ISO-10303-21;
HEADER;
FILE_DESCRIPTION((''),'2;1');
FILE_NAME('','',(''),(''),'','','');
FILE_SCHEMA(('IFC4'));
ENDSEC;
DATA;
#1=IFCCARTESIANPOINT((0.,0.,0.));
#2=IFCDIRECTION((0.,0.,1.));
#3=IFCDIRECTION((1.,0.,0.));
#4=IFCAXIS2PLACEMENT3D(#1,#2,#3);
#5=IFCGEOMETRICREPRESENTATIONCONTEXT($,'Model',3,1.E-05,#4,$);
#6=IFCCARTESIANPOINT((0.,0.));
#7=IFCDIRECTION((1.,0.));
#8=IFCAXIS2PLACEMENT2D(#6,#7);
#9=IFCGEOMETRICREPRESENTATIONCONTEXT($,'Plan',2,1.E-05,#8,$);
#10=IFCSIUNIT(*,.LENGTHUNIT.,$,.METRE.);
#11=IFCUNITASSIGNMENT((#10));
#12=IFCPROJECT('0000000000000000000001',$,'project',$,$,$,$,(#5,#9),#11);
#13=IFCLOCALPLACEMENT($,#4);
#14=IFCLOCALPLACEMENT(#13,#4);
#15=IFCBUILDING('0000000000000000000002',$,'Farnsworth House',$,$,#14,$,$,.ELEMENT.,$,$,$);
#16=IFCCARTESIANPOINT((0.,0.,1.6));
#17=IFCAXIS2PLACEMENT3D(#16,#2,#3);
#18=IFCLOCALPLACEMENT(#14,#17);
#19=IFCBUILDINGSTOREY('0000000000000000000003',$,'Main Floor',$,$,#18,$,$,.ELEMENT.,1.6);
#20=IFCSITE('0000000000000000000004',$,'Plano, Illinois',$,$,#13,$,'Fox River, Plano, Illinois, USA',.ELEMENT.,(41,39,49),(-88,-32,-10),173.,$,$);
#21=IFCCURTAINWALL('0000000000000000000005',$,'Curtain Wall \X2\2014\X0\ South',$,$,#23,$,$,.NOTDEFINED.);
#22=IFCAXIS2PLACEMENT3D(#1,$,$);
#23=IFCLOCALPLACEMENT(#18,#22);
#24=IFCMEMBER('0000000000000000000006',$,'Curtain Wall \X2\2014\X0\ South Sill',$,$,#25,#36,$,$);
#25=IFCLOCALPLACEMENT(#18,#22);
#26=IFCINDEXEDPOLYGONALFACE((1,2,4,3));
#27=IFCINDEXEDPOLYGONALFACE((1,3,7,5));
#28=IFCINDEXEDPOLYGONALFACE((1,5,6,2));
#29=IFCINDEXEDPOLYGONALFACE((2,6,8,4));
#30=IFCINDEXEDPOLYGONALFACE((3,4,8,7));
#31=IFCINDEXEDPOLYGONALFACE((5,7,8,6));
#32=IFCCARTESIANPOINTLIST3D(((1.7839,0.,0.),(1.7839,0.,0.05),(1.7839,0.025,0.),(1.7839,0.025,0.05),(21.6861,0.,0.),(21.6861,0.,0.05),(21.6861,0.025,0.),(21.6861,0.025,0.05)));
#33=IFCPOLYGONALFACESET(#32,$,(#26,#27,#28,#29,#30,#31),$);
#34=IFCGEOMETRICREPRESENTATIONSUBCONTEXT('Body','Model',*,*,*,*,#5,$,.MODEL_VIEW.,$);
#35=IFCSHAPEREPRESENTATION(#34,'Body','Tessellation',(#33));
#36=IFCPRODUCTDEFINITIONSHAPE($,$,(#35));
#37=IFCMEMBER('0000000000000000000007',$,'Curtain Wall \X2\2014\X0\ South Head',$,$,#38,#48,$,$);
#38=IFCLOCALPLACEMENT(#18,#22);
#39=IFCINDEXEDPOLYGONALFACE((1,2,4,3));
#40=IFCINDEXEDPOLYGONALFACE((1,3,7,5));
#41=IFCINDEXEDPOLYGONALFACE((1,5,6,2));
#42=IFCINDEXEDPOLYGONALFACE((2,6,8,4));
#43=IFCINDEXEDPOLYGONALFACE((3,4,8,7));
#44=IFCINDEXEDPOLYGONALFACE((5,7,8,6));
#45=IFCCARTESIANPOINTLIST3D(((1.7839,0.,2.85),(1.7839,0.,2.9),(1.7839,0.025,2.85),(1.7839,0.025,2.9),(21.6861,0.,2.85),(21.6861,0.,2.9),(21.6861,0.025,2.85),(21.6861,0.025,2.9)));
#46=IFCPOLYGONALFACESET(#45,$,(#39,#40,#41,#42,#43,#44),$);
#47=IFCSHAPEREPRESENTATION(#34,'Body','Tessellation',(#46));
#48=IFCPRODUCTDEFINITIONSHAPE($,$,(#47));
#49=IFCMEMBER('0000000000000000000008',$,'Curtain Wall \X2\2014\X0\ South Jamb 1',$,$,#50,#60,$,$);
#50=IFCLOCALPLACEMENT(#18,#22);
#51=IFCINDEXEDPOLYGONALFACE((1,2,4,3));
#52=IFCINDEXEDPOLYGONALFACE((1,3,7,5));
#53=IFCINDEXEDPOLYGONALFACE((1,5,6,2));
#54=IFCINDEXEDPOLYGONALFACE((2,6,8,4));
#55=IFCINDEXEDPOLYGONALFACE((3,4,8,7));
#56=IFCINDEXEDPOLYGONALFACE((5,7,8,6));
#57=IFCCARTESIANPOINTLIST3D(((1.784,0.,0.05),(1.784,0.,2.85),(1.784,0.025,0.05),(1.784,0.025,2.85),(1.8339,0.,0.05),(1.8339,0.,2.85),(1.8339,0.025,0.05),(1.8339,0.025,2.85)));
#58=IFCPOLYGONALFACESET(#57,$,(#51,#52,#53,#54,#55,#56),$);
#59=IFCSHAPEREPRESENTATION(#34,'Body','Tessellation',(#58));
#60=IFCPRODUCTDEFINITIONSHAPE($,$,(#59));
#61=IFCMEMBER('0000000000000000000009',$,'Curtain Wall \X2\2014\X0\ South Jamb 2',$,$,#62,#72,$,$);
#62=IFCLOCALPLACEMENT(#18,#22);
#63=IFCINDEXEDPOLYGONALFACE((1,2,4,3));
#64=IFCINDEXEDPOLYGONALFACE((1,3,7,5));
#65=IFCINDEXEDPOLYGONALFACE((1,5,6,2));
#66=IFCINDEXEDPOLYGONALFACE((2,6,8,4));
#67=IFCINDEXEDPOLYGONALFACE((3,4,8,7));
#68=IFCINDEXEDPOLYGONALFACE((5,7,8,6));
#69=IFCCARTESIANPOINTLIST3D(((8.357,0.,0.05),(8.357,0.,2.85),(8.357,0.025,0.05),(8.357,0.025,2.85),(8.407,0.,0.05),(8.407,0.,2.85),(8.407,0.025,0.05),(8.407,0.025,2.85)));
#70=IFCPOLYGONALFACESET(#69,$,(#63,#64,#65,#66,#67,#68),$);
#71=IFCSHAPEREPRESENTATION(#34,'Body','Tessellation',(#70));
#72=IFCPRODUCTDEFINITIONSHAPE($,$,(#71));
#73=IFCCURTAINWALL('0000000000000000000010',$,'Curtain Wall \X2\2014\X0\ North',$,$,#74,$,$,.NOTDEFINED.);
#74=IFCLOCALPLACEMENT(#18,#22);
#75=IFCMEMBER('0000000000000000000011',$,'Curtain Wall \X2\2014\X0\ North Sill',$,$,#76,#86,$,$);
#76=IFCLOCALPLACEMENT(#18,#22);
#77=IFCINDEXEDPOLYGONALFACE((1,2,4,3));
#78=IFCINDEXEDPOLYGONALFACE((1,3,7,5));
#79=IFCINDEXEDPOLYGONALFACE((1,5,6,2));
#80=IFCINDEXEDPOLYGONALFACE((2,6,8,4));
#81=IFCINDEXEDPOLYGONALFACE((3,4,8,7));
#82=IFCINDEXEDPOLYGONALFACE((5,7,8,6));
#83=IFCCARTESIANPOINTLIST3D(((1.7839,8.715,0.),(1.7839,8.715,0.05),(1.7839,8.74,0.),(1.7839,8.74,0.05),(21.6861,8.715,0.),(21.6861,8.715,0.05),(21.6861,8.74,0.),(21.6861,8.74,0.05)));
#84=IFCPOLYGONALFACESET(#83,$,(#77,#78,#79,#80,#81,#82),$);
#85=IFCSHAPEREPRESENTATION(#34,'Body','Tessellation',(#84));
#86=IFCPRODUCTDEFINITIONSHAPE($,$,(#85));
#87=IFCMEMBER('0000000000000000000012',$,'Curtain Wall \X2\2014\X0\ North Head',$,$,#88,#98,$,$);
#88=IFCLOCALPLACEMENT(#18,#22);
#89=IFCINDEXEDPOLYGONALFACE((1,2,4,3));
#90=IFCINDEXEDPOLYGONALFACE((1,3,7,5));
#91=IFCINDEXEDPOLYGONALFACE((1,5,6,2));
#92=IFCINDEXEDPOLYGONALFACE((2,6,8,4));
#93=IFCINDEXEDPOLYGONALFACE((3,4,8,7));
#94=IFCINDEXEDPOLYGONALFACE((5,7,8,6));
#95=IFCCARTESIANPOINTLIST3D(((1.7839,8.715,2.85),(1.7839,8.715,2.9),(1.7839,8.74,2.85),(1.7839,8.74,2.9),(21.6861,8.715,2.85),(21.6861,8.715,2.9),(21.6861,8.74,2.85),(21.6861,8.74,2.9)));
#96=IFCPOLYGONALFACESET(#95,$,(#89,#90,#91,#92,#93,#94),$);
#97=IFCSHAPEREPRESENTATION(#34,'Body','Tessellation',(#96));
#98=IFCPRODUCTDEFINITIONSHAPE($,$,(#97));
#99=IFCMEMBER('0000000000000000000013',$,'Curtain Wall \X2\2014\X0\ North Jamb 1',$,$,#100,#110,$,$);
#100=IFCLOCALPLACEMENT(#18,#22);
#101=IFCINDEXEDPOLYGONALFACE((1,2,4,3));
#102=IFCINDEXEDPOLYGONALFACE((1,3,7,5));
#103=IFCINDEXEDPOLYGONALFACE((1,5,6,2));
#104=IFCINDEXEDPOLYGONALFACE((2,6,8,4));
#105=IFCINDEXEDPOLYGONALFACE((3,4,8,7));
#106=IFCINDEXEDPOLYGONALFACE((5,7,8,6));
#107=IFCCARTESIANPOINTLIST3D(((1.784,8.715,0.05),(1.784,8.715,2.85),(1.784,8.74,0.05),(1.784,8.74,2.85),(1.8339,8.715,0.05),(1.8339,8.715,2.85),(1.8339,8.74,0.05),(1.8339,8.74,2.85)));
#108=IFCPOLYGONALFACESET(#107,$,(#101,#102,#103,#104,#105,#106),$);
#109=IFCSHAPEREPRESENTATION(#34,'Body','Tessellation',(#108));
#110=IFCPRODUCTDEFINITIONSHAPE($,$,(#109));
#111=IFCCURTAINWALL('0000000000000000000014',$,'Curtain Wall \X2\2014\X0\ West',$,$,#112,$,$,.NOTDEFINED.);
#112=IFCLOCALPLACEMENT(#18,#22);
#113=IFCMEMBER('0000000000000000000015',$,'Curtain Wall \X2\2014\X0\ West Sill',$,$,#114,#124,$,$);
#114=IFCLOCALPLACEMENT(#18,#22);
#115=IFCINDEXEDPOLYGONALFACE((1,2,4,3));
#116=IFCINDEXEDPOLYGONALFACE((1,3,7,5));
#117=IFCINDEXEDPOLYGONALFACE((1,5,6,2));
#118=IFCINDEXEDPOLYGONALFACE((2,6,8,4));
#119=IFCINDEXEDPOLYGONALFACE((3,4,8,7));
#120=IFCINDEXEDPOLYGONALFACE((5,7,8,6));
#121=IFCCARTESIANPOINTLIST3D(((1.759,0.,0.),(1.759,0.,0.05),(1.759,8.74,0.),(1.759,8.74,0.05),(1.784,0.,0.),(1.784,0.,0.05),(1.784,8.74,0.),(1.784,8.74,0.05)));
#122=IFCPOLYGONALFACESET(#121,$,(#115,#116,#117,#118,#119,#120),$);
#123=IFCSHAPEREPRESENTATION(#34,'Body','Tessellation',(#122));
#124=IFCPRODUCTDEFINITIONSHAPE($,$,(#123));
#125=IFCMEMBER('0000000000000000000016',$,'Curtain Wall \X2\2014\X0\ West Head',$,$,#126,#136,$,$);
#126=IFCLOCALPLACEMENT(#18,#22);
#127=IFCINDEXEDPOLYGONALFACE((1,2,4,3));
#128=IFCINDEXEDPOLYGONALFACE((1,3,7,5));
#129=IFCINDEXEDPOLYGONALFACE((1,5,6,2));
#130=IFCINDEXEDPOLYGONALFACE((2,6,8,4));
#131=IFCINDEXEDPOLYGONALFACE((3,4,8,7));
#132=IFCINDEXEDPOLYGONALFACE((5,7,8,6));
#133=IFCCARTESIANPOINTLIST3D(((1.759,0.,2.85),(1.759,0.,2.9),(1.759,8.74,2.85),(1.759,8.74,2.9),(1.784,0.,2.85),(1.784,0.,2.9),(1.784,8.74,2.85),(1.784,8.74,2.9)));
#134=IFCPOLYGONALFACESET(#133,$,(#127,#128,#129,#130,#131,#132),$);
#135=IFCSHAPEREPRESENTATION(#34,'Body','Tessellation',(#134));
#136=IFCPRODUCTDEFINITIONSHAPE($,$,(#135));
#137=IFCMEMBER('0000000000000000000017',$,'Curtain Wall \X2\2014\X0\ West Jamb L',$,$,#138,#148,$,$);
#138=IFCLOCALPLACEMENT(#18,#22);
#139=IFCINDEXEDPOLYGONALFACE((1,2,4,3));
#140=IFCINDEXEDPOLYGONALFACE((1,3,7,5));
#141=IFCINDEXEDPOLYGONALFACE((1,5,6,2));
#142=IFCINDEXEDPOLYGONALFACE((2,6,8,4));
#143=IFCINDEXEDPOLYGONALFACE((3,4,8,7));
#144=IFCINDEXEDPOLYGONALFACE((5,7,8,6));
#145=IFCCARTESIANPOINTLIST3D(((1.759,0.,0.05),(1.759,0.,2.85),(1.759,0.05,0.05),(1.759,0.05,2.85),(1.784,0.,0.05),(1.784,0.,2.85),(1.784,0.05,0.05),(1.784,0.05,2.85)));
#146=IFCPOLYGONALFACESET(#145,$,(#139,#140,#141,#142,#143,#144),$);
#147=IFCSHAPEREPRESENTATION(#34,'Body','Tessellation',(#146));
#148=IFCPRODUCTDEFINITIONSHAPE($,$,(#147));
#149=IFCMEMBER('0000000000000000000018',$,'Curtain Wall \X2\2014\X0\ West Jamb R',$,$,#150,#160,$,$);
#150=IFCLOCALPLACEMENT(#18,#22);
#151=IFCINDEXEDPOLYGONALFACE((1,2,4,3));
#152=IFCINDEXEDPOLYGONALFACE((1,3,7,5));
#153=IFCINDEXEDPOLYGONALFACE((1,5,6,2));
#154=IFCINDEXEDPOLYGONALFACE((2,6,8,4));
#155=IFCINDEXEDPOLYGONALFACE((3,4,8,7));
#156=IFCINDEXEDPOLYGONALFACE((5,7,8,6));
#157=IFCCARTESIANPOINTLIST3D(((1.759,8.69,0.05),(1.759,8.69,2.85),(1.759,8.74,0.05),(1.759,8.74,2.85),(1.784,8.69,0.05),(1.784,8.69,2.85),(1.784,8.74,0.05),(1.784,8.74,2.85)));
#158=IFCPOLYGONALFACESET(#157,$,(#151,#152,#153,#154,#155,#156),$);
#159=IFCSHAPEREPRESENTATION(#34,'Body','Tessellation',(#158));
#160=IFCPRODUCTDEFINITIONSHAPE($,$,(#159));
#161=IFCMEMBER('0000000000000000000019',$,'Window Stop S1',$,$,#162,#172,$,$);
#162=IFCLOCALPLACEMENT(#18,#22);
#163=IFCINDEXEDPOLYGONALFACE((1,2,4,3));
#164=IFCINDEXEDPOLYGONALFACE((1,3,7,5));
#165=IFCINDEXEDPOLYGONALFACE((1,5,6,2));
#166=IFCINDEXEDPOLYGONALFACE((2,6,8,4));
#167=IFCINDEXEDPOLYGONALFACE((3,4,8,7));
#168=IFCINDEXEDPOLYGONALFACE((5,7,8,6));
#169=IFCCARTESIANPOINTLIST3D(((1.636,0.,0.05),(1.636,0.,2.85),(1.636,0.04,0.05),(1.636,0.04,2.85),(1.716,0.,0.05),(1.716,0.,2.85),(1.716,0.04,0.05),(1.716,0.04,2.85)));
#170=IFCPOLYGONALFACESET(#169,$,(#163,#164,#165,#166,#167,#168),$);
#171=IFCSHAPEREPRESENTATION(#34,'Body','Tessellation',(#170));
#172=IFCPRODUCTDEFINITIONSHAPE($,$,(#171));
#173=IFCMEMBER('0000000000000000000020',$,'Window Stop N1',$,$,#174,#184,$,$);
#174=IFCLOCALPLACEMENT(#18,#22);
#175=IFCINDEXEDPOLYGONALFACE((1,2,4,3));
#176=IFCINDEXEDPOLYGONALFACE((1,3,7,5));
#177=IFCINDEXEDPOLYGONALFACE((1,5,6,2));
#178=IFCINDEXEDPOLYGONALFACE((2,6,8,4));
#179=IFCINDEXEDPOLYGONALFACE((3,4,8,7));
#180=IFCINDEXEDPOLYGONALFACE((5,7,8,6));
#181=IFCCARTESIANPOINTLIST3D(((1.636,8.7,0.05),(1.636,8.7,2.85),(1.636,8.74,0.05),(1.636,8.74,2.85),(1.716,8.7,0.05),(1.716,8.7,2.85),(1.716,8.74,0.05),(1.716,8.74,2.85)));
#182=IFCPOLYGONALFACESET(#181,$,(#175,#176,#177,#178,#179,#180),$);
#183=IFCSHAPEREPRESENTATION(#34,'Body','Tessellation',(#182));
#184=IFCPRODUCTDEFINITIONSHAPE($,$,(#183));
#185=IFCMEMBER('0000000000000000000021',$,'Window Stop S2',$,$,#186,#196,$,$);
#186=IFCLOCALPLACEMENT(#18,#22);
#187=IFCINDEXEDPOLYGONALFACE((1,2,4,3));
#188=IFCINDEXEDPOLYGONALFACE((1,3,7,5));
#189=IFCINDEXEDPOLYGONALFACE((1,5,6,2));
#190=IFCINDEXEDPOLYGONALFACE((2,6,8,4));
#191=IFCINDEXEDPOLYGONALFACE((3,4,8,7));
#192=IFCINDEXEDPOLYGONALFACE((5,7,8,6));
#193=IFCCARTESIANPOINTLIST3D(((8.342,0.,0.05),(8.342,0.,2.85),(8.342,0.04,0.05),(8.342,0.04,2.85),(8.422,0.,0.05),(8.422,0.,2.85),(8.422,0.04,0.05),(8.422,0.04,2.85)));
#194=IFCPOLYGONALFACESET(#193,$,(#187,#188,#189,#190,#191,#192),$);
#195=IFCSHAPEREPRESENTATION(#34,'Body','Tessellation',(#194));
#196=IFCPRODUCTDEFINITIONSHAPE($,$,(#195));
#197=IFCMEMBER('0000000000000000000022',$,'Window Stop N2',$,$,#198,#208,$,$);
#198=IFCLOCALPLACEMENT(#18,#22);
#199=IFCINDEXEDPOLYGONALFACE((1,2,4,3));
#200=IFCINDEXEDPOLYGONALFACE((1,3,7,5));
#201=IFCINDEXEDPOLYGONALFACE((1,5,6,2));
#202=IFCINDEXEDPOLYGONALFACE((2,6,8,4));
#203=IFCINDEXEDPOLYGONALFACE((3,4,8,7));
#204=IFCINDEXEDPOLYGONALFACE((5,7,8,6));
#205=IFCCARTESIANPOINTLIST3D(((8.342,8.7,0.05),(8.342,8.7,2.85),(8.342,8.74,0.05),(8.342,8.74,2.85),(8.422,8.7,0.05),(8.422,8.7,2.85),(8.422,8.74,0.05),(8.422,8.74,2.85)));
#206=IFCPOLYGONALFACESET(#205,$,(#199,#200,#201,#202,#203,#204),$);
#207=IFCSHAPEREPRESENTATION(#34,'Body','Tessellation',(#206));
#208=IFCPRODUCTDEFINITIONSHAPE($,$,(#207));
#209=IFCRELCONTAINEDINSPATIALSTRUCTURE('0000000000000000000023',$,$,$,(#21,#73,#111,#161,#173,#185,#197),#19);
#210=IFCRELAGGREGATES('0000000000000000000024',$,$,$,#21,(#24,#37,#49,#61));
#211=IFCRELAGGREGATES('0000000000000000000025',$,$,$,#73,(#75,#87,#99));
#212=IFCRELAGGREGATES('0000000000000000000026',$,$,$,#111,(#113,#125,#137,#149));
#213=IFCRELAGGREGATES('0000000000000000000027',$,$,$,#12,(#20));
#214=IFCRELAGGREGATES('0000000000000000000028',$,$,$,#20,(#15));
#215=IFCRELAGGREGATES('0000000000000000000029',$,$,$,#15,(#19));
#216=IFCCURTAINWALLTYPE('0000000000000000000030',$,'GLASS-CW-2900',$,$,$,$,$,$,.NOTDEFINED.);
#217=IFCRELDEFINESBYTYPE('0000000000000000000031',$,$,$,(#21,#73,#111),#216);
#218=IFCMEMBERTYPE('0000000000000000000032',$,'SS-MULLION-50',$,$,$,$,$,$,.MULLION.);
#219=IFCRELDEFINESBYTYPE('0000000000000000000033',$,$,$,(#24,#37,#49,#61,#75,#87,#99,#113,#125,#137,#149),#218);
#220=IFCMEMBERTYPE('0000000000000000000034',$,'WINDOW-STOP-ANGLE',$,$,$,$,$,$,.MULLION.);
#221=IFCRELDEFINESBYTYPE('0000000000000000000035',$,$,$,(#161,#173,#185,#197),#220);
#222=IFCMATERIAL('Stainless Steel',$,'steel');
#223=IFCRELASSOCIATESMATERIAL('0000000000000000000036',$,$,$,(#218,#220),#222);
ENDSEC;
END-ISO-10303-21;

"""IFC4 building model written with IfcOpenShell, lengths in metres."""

from ifc_helpers import new_model, si_unit, frame, origin_with_axes, origin_2d_with_axis, place, context, subcontext, project, spatial, rectangle, extrude, material, type_object, element, aggregate, save


model = new_model("IFC4")

# Units and contexts
model_context = context("Model", 3, precision=1e-05, world=origin_with_axes())
plan_context = context("Plan", 2, precision=1e-05, world=origin_2d_with_axis())
body_context = subcontext(model_context, "Body", "Model", "MODEL_VIEW")
ifc_project = project(units=[si_unit("LENGTHUNIT", "METRE")], contexts=[model_context, plan_context])

# Site, building, storey
site_placement = place(None, origin_with_axes())
site = spatial("IfcSite", under=ifc_project, at=site_placement, Name="Plano, Illinois", LongName="Fox River, Plano, Illinois, USA", CompositionType="ELEMENT", RefLatitude=(41, 39, 49), RefLongitude=(-88, -32, -10), RefElevation=173.0)
building_placement = place(site_placement, origin_with_axes())
building = spatial("IfcBuilding", under=site, at=building_placement, Name="Farnsworth House", CompositionType="ELEMENT")
storey_placement = place(building_placement, frame((0.0, 0.0, 1.6), z_axis=(0.0, 0.0, 1.0), x_axis=(1.0, 0.0, 0.0)))
storey = spatial("IfcBuildingStorey", under=building, at=storey_placement, Name="Main Floor", CompositionType="ELEMENT", Elevation=1.6)

# Curtain walls, members
curtain_wall_type = type_object("IfcCurtainWallType", Name="GLASS-CW-2900", PredefinedType="NOTDEFINED")
curtain_wall_1_placement = place(storey_placement, frame((1.7839, 0.0, 0.0), z_axis=(0.0, 0.0, 1.0), x_axis=(1.0, 0.0, 0.0)))
curtain_wall_1 = element("IfcCurtainWall", 1, at=curtain_wall_1_placement, inside=storey, type_object=curtain_wall_type, Name="Curtain Wall — South", PredefinedType="NOTDEFINED")
ifc_material_1 = material(Name="Stainless Steel", Category="steel")
member_type_1 = type_object("IfcMemberType", Name="SS-MULLION-50", PredefinedType="MULLION", material=ifc_material_1)
member_1_placement = place(curtain_wall_1_placement, origin_with_axes())
member_1 = element("IfcMember", 2, at=member_1_placement, type_object=member_type_1, Name="Curtain Wall — South Sill", context=body_context, shape_type="SweptSolid", body=[
    extrude(rectangle(XDim=19.9021, YDim=0.025, at=origin_2d_with_axis()), frame((9.9511, 0.0125, 0.0), z_axis=(0.0, 0.0, 1.0), x_axis=(1.0, 0.0, 0.0)), (0.0, 0.0, 1.0), 0.05),
])
member_2_placement = place(curtain_wall_1_placement, frame((0.0, 0.0, 2.85), z_axis=(0.0, 0.0, 1.0), x_axis=(1.0, 0.0, 0.0)))
member_2 = element("IfcMember", 3, at=member_2_placement, type_object=member_type_1, Name="Curtain Wall — South Head", context=body_context, shape_type="SweptSolid", body=[
    extrude(rectangle(XDim=19.9021, YDim=0.025, at=origin_2d_with_axis()), frame((9.9511, 0.0125, 0.0), z_axis=(0.0, 0.0, 1.0), x_axis=(1.0, 0.0, 0.0)), (0.0, 0.0, 1.0), 0.05),
])
member_3_placement = place(curtain_wall_1_placement, frame((0.0, 0.0, 0.05), z_axis=(0.0, 0.0, 1.0), x_axis=(1.0, 0.0, 0.0)))
member_3 = element("IfcMember", 4, at=member_3_placement, type_object=member_type_1, Name="Curtain Wall — South Jamb 1", context=body_context, shape_type="SweptSolid", body=[
    extrude(rectangle(XDim=0.05, YDim=0.025, at=origin_2d_with_axis()), frame((0.025, 0.0125, 0.0), z_axis=(0.0, 0.0, 1.0), x_axis=(1.0, 0.0, 0.0)), (0.0, 0.0, 1.0), 2.8),
])
member_4_placement = place(curtain_wall_1_placement, frame((6.573, 0.0, 0.05), z_axis=(0.0, 0.0, 1.0), x_axis=(1.0, 0.0, 0.0)))
member_4 = element("IfcMember", 5, at=member_4_placement, type_object=member_type_1, Name="Curtain Wall — South Jamb 2", context=body_context, shape_type="SweptSolid", body=[
    extrude(rectangle(XDim=0.05, YDim=0.025, at=origin_2d_with_axis()), frame((0.025, 0.0125, 0.0), z_axis=(0.0, 0.0, 1.0), x_axis=(1.0, 0.0, 0.0)), (0.0, 0.0, 1.0), 2.8),
])
curtain_wall_2_placement = place(storey_placement, frame((1.7839, 8.715, 0.0), z_axis=(0.0, 0.0, 1.0), x_axis=(1.0, 0.0, 0.0)))
curtain_wall_2 = element("IfcCurtainWall", 6, at=curtain_wall_2_placement, inside=storey, type_object=curtain_wall_type, Name="Curtain Wall — North", PredefinedType="NOTDEFINED")
member_5_placement = place(curtain_wall_2_placement, origin_with_axes())
member_5 = element("IfcMember", 7, at=member_5_placement, type_object=member_type_1, Name="Curtain Wall — North Sill", context=body_context, shape_type="SweptSolid", body=[
    extrude(rectangle(XDim=19.9021, YDim=0.025, at=origin_2d_with_axis()), frame((9.9511, 0.0125, 0.0), z_axis=(0.0, 0.0, 1.0), x_axis=(1.0, 0.0, 0.0)), (0.0, 0.0, 1.0), 0.05),
])
member_6_placement = place(curtain_wall_2_placement, frame((0.0, 0.0, 2.85), z_axis=(0.0, 0.0, 1.0), x_axis=(1.0, 0.0, 0.0)))
member_6 = element("IfcMember", 8, at=member_6_placement, type_object=member_type_1, Name="Curtain Wall — North Head", context=body_context, shape_type="SweptSolid", body=[
    extrude(rectangle(XDim=19.9021, YDim=0.025, at=origin_2d_with_axis()), frame((9.9511, 0.0125, 0.0), z_axis=(0.0, 0.0, 1.0), x_axis=(1.0, 0.0, 0.0)), (0.0, 0.0, 1.0), 0.05),
])
member_7_placement = place(curtain_wall_2_placement, frame((0.0, 0.0, 0.05), z_axis=(0.0, 0.0, 1.0), x_axis=(1.0, 0.0, 0.0)))
member_7 = element("IfcMember", 9, at=member_7_placement, type_object=member_type_1, Name="Curtain Wall — North Jamb 1", context=body_context, shape_type="SweptSolid", body=[
    extrude(rectangle(XDim=0.05, YDim=0.025, at=origin_2d_with_axis()), frame((0.025, 0.0125, 0.0), z_axis=(0.0, 0.0, 1.0), x_axis=(1.0, 0.0, 0.0)), (0.0, 0.0, 1.0), 2.8),
])
curtain_wall_3_placement = place(storey_placement, frame((1.7839, 0.0, 0.0), z_axis=(0.0, 0.0, 1.0), x_axis=(0.0, 1.0, 0.0)))
curtain_wall_3 = element("IfcCurtainWall", 10, at=curtain_wall_3_placement, inside=storey, type_object=curtain_wall_type, Name="Curtain Wall — West", PredefinedType="NOTDEFINED")
member_8_placement = place(curtain_wall_3_placement, origin_with_axes())
member_8 = element("IfcMember", 11, at=member_8_placement, type_object=member_type_1, Name="Curtain Wall — West Sill", context=body_context, shape_type="SweptSolid", body=[
    extrude(rectangle(XDim=8.74, YDim=0.025, at=origin_2d_with_axis()), frame((4.37, 0.0125, 0.0), z_axis=(0.0, 0.0, 1.0), x_axis=(1.0, 0.0, 0.0)), (0.0, 0.0, 1.0), 0.05),
])
member_9_placement = place(curtain_wall_3_placement, frame((0.0, 0.0, 2.85), z_axis=(0.0, 0.0, 1.0), x_axis=(1.0, 0.0, 0.0)))
member_9 = element("IfcMember", 12, at=member_9_placement, type_object=member_type_1, Name="Curtain Wall — West Head", context=body_context, shape_type="SweptSolid", body=[
    extrude(rectangle(XDim=8.74, YDim=0.025, at=origin_2d_with_axis()), frame((4.37, 0.0125, 0.0), z_axis=(0.0, 0.0, 1.0), x_axis=(1.0, 0.0, 0.0)), (0.0, 0.0, 1.0), 0.05),
])
member_10_placement = place(curtain_wall_3_placement, frame((0.0, 0.0, 0.05), z_axis=(0.0, 0.0, 1.0), x_axis=(1.0, 0.0, 0.0)))
member_10 = element("IfcMember", 13, at=member_10_placement, type_object=member_type_1, Name="Curtain Wall — West Jamb L", context=body_context, shape_type="SweptSolid", body=[
    extrude(rectangle(XDim=0.05, YDim=0.025, at=origin_2d_with_axis()), frame((0.025, 0.0125, 0.0), z_axis=(0.0, 0.0, 1.0), x_axis=(1.0, 0.0, 0.0)), (0.0, 0.0, 1.0), 2.8),
])
member_11_placement = place(curtain_wall_3_placement, frame((8.69, 0.0, 0.05), z_axis=(0.0, 0.0, 1.0), x_axis=(1.0, 0.0, 0.0)))
member_11 = element("IfcMember", 14, at=member_11_placement, type_object=member_type_1, Name="Curtain Wall — West Jamb R", context=body_context, shape_type="SweptSolid", body=[
    extrude(rectangle(XDim=0.05, YDim=0.025, at=origin_2d_with_axis()), frame((0.025, 0.0125, 0.0), z_axis=(0.0, 0.0, 1.0), x_axis=(1.0, 0.0, 0.0)), (0.0, 0.0, 1.0), 2.8),
])

# Members
member_type_2 = type_object("IfcMemberType", Name="WINDOW-STOP-ANGLE", PredefinedType="MULLION", material=ifc_material_1)
for number, where, z_axis, x_axis, name in (
    (15, (1.636, 0.0, 0.05), (0.0, 0.0, 1.0), (1.0, 0.0, 0.0), "Window Stop S1"),
    (16, (1.636, 8.7, 0.05), (0.0, 0.0, 1.0), (1.0, 0.0, 0.0), "Window Stop N1"),
    (17, (8.342, 0.0, 0.05), (0.0, 0.0, 1.0), (1.0, 0.0, 0.0), "Window Stop S2"),
    (18, (8.342, 8.7, 0.05), (0.0, 0.0, 1.0), (1.0, 0.0, 0.0), "Window Stop N2"),
):
    element("IfcMember", number, at=place(storey_placement, frame(where, z_axis=z_axis, x_axis=x_axis)), inside=storey, type_object=member_type_2, Name=name, context=body_context, shape_type="SweptSolid", body=[
        extrude(rectangle(XDim=0.08, YDim=0.04, at=origin_2d_with_axis()), frame((0.04, 0.02, 0.0), z_axis=(0.0, 0.0, 1.0), x_axis=(1.0, 0.0, 0.0)), (0.0, 0.0, 1.0), 2.8),
    ])

aggregate(curtain_wall_1, [member_1, member_2, member_3, member_4])
aggregate(curtain_wall_2, [member_5, member_6, member_7])
aggregate(curtain_wall_3, [member_8, member_9, member_10, member_11])

save(model, "model.ifc")
